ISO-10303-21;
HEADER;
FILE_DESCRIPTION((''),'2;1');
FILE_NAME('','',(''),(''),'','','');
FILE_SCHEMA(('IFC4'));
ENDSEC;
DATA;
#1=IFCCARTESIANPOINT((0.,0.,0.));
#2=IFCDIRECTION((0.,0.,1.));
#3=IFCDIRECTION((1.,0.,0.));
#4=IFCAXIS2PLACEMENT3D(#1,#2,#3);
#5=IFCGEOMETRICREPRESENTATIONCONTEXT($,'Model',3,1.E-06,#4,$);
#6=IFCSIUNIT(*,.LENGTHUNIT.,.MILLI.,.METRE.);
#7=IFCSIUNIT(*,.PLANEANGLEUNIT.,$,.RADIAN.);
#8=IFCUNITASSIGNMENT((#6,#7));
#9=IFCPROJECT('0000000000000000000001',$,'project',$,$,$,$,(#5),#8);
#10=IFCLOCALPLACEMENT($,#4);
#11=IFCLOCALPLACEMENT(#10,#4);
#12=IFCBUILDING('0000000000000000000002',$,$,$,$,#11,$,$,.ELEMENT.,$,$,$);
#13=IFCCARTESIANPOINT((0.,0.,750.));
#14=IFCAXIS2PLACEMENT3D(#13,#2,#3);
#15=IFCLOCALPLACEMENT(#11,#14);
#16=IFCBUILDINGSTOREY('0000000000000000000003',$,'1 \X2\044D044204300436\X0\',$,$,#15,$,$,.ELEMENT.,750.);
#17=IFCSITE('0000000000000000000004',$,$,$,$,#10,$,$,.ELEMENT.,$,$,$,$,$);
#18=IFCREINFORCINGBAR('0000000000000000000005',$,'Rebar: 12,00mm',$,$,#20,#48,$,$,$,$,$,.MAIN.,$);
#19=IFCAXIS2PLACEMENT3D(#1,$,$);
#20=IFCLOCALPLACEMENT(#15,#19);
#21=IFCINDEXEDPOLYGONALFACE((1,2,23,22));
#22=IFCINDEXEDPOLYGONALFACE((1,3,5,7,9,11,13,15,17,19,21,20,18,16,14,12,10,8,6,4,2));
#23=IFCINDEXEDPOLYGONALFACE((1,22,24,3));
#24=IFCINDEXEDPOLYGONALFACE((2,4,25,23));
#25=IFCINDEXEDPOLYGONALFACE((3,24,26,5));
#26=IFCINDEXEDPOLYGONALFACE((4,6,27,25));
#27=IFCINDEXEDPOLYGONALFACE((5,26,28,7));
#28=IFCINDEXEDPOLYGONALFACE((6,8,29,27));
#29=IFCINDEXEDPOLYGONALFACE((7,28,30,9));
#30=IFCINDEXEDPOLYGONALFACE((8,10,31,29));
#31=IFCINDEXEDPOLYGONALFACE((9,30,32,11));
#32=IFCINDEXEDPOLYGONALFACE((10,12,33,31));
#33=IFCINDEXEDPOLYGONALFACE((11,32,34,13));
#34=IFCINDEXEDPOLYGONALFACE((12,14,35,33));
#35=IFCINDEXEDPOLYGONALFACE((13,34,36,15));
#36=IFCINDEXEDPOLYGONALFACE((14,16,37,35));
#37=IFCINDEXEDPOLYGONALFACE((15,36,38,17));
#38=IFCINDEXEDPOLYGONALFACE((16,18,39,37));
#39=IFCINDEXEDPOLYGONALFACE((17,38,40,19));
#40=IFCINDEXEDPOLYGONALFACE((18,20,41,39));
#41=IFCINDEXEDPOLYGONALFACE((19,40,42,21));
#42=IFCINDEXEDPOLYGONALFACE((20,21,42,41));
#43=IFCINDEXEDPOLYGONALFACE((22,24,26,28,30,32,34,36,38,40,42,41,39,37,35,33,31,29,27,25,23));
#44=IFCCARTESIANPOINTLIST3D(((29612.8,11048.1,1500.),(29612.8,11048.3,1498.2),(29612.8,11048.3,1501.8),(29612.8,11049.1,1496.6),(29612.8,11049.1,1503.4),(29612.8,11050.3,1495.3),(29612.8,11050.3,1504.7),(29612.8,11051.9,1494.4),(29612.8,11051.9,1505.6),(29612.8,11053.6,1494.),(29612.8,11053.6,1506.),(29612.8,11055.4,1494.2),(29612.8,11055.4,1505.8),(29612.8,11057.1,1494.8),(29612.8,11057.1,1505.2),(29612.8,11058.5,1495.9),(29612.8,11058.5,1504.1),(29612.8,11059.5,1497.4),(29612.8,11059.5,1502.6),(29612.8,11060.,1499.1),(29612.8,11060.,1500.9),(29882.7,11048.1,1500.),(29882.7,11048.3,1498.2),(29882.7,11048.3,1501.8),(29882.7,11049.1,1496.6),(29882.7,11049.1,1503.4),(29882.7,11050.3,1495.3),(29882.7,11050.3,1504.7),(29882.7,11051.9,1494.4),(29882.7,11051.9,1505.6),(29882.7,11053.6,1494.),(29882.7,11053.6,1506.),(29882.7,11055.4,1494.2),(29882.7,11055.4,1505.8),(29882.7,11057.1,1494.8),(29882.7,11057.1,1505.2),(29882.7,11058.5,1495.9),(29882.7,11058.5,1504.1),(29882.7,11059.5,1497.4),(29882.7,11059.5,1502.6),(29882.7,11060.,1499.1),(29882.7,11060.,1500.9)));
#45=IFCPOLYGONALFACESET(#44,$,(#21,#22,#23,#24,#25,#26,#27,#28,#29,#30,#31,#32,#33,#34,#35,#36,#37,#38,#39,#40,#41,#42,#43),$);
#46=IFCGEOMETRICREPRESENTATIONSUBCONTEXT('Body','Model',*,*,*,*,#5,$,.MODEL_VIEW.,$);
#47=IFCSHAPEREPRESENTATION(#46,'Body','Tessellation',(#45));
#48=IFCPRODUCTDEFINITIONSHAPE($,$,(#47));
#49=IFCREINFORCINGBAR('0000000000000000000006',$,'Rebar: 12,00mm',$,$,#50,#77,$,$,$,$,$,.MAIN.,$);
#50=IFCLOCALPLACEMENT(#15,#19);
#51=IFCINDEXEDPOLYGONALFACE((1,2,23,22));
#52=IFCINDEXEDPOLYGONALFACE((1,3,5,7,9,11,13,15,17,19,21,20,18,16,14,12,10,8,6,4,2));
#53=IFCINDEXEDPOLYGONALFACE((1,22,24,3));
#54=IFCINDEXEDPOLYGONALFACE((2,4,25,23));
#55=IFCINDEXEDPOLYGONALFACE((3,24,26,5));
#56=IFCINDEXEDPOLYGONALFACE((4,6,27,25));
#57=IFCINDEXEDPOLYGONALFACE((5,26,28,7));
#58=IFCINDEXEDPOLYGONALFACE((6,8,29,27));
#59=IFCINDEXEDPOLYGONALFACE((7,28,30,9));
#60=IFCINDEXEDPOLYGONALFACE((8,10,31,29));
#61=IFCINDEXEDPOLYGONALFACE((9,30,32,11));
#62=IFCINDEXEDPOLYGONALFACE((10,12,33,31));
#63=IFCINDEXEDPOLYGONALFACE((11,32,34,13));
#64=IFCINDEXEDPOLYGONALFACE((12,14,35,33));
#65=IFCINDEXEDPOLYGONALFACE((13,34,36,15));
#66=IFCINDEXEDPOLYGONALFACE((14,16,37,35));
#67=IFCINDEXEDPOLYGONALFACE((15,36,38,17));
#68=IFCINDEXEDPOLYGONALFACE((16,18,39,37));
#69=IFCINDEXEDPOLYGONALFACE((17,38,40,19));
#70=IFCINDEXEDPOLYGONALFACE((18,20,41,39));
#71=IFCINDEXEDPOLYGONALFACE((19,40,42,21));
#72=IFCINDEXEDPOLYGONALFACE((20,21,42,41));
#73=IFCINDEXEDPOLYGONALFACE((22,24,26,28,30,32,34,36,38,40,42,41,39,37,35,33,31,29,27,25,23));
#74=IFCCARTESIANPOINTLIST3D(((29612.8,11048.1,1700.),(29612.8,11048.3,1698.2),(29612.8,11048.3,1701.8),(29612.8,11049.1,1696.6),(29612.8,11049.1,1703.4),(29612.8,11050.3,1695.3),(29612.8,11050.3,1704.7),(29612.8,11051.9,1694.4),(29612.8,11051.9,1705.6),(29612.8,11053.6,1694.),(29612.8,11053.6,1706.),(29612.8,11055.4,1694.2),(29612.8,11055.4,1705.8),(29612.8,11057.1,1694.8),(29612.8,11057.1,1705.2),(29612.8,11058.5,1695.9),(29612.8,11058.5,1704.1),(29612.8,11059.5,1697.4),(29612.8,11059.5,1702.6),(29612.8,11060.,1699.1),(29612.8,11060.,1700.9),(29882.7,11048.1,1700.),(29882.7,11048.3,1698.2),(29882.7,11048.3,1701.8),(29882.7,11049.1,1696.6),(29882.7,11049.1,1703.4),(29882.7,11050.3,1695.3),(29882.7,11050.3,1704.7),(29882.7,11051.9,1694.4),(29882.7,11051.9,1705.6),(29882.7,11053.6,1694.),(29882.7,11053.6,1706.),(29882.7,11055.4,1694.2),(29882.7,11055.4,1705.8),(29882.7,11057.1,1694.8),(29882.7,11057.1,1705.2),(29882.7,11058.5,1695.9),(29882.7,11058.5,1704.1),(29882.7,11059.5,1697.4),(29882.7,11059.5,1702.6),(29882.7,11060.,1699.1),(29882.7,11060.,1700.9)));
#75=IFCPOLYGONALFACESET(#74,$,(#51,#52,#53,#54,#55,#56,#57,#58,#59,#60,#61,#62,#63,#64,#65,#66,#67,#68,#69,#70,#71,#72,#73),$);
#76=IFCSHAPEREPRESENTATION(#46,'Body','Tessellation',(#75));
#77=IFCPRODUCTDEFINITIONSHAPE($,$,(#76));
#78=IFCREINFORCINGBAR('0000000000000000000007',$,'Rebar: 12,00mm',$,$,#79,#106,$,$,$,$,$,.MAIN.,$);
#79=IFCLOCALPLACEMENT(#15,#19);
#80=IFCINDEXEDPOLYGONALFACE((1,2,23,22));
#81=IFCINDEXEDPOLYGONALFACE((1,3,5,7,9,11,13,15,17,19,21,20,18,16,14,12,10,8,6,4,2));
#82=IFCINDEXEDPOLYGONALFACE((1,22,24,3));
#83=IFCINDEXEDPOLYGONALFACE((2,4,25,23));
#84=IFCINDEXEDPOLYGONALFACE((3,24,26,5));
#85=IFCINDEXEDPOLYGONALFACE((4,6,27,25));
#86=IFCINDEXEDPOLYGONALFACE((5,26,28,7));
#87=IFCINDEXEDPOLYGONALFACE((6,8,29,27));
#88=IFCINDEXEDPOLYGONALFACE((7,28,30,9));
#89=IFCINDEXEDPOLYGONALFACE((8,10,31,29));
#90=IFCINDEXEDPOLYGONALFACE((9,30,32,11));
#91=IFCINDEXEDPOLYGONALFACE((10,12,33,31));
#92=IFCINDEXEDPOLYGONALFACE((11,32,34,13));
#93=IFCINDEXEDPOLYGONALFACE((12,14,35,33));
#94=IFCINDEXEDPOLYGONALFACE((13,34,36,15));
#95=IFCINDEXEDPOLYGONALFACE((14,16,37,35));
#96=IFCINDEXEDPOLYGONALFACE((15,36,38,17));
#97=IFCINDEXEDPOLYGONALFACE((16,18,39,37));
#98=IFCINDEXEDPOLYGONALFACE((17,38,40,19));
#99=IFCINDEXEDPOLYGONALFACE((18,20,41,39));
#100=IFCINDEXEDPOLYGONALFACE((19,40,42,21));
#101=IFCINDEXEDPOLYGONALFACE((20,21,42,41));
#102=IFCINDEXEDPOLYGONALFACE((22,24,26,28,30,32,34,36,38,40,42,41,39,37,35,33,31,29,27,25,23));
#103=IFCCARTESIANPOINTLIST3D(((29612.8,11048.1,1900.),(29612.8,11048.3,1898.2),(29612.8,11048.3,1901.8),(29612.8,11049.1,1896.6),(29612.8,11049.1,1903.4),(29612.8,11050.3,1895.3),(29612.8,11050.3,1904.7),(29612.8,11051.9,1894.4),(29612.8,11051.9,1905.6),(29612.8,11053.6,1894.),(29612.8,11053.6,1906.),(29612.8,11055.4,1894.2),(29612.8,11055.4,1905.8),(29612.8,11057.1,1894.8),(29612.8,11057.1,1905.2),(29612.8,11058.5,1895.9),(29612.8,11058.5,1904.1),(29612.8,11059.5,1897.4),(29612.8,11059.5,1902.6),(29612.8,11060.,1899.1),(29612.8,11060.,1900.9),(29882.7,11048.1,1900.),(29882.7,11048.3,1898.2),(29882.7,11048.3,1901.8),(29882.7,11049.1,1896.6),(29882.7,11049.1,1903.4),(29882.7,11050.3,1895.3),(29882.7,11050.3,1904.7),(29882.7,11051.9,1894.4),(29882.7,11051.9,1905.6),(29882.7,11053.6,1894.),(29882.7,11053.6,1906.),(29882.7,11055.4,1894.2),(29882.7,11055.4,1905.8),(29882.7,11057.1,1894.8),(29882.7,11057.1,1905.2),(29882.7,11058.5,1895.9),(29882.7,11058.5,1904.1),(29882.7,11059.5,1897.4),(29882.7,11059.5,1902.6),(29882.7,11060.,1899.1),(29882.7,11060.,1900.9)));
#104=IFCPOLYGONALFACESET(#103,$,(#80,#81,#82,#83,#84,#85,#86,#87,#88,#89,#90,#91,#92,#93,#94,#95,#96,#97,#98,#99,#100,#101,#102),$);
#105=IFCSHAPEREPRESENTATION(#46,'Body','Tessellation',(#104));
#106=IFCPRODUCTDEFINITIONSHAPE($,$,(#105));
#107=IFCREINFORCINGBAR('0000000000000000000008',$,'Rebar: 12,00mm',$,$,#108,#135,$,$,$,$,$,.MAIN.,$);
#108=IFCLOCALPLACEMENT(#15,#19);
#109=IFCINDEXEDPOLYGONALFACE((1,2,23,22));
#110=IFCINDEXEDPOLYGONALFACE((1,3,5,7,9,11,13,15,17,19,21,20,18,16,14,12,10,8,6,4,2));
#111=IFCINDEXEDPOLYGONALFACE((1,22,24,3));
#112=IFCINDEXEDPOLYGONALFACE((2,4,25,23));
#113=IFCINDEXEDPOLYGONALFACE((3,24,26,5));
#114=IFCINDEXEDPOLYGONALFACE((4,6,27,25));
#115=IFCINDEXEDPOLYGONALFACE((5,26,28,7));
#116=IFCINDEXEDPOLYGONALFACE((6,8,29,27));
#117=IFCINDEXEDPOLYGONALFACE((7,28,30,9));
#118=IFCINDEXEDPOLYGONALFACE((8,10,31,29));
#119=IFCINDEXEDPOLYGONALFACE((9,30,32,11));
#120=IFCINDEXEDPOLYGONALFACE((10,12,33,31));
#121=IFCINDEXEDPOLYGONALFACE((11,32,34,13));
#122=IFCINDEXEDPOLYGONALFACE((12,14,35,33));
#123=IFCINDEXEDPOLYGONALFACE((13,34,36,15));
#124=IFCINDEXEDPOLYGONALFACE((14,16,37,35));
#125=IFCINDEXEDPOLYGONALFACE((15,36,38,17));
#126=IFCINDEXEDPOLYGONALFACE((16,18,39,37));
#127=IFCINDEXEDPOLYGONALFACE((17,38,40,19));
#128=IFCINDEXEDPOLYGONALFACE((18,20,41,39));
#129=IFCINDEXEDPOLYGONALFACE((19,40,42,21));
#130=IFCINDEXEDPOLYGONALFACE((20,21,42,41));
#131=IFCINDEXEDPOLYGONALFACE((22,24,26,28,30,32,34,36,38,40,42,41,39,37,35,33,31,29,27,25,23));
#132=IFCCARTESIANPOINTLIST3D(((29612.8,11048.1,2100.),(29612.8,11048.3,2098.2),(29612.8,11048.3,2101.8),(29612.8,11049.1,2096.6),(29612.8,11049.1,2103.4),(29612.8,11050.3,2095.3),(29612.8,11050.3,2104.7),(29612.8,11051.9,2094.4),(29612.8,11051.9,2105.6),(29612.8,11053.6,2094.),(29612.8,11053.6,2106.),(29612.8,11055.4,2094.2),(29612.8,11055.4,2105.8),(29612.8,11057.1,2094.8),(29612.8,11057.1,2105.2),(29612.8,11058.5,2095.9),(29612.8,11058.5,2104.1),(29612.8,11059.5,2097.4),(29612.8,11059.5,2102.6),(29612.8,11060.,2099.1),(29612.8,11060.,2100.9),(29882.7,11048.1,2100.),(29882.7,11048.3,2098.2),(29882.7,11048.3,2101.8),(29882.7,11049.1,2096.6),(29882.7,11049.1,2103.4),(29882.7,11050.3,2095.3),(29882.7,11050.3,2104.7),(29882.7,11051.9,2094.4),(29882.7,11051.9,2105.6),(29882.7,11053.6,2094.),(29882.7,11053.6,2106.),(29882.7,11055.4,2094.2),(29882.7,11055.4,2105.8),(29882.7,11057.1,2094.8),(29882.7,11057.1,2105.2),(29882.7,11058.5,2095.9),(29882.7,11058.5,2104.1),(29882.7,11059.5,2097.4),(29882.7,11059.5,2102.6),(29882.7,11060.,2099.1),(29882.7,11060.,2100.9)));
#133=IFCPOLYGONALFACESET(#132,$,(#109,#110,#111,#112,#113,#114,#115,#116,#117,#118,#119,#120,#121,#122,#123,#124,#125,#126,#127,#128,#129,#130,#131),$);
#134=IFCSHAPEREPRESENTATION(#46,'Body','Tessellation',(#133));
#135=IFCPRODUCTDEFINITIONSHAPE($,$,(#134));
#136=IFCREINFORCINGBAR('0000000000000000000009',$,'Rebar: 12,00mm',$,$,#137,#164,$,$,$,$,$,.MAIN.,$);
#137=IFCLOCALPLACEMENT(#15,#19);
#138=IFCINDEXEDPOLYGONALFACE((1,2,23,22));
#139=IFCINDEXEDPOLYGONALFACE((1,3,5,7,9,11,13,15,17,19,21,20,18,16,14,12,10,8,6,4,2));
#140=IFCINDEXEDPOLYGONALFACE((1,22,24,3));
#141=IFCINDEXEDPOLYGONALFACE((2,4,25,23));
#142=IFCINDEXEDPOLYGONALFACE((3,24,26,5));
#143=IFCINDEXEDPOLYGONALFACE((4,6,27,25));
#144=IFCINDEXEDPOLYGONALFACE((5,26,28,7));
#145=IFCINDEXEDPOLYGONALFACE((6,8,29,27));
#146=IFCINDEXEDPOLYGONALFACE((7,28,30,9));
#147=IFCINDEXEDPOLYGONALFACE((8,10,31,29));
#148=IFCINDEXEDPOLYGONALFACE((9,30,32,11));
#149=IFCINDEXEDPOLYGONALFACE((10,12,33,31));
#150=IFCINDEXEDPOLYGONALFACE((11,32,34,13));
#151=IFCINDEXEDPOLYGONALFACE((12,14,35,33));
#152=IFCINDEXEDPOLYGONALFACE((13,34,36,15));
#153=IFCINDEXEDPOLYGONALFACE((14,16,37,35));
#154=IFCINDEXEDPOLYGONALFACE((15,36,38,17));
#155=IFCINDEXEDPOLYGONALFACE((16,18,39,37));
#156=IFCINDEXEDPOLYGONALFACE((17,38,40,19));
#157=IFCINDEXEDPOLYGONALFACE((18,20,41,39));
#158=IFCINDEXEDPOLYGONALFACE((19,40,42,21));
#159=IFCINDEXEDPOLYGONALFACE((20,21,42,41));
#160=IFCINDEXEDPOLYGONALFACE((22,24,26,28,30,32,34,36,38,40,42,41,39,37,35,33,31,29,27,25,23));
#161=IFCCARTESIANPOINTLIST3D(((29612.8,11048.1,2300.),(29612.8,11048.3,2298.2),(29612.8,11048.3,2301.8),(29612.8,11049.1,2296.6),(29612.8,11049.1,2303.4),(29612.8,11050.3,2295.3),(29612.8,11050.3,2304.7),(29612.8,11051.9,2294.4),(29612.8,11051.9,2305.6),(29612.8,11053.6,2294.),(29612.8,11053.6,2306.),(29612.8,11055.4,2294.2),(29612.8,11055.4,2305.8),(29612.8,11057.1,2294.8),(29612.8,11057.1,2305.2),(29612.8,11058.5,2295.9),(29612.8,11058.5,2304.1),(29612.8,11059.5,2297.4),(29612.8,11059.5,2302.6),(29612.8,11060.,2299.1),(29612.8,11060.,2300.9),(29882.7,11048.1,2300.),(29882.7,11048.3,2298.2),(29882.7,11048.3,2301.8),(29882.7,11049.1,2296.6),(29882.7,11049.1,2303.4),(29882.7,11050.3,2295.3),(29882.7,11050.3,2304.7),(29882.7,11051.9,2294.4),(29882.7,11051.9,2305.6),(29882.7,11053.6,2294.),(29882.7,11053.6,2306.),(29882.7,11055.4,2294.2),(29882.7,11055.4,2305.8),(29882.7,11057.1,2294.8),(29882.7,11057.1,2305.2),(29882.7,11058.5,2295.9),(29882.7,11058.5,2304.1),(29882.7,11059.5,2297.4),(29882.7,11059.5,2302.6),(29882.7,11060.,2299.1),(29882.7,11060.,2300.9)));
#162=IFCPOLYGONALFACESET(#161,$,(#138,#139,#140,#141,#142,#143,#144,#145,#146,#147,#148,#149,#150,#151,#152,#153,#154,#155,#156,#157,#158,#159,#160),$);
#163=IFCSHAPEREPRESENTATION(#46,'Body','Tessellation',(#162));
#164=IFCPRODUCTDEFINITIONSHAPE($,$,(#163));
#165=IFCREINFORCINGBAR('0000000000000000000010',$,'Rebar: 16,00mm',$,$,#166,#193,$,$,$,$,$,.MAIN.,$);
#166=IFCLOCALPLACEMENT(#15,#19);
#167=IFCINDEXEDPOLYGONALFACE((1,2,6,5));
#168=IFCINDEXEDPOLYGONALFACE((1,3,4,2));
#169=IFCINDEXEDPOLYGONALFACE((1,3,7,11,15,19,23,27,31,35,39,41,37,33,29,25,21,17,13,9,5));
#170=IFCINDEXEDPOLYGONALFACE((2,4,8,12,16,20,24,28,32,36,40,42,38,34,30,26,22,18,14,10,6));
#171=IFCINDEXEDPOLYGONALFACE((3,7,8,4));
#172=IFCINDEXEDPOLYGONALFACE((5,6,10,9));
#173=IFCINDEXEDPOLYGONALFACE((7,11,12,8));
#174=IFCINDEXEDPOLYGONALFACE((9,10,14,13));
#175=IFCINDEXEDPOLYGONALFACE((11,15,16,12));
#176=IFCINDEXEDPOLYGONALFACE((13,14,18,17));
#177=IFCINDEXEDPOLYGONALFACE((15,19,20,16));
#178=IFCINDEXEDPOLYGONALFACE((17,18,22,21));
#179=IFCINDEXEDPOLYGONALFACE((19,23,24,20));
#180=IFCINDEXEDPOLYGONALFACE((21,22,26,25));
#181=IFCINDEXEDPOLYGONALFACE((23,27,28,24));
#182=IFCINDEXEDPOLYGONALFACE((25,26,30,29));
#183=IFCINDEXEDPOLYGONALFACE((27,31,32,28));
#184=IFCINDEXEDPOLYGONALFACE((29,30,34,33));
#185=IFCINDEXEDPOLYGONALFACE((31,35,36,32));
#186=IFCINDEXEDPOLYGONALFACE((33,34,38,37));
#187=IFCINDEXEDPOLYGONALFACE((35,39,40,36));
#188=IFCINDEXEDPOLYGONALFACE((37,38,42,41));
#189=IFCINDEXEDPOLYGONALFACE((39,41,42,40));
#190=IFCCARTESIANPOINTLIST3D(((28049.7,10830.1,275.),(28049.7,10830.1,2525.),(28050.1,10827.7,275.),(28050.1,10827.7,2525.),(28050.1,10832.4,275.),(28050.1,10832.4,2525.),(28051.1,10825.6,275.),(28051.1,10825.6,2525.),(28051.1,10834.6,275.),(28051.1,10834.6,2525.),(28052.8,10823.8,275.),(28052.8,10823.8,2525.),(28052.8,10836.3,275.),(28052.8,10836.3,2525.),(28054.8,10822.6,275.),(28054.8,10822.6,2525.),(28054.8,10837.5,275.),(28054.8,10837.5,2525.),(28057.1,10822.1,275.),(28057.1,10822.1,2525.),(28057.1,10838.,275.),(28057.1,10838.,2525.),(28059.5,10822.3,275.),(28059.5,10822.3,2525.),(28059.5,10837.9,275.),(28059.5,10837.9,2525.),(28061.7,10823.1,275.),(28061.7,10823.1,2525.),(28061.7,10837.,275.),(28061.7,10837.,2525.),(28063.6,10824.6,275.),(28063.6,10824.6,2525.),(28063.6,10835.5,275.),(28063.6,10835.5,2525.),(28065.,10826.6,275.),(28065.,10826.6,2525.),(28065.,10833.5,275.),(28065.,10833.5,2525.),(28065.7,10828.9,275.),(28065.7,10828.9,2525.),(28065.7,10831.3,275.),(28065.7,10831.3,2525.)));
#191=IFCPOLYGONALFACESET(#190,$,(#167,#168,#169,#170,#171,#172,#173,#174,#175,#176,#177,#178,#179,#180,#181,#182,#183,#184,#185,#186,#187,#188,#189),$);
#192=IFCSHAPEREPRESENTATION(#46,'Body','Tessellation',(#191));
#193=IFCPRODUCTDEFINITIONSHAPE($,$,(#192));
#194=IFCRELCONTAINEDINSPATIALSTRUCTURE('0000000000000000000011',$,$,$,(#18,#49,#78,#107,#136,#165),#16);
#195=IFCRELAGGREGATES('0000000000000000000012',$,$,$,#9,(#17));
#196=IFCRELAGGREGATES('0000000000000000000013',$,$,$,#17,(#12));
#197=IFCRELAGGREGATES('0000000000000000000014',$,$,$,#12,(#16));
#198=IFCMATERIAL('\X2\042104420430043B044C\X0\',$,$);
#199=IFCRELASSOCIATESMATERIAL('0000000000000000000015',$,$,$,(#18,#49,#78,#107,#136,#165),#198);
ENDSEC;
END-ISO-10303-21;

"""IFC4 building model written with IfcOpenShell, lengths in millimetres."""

from ifc_helpers import new_model, entity, si_unit, frame, origin_with_axes, place, context, subcontext, project, spatial, source, transform, mapped, material, element, save


model = new_model("IFC4")

# Units and contexts
model_context = context("Model", 3, precision=1e-06, world=origin_with_axes())
body_context = subcontext(model_context, "Body", "Model", "MODEL_VIEW")
ifc_project = project(units=[si_unit("LENGTHUNIT", "METRE", prefix="MILLI"), si_unit("PLANEANGLEUNIT", "RADIAN")], contexts=[model_context])

# Site, building, storey
site_placement = place(None, origin_with_axes())
site = spatial("IfcSite", under=ifc_project, at=site_placement, CompositionType="ELEMENT")
building_placement = place(site_placement, origin_with_axes())
building = spatial("IfcBuilding", under=site, at=building_placement, CompositionType="ELEMENT")
storey_placement = place(building_placement, frame((0.0, 0.0, 750.0), z_axis=(0.0, 0.0, 1.0), x_axis=(1.0, 0.0, 0.0)))
storey = spatial("IfcBuildingStorey", under=building, at=storey_placement, Name="1 этаж", CompositionType="ELEMENT", Elevation=750.0)

# Reinforcing bars
ifc_material = material(Name="Сталь")
shared_shape_1 = source(origin_with_axes(), body_context, "Body", "AdvancedSweptSolid", [
    entity("IfcSweptDiskSolid", entity("IfcIndexedPolyCurve", entity("IfcCartesianPointList3D", [[0.0, 0.0, 0.0], [270.0, 0.0, 0.0]]), [entity("IfcLineIndex", [1, 2])]), 6.0),
])
reinforcing_bar_1_placement = place(storey_placement, origin_with_axes())
element("IfcReinforcingBar", 1, at=reinforcing_bar_1_placement, inside=storey, material=ifc_material, Name="Rebar: 12,00mm", PredefinedType="MAIN", context=body_context, shape_type="MappedRepresentation", body=[
    mapped(shared_shape_1, transform((29882.7, 11054.1, 1500.0), x_axis=(-1.0, 0.0, 0.0), y_axis=(0.0, -1.0, 0.0), z_axis=(0.0, 0.0, 1.0), scale=1.0)),
])
reinforcing_bar_2_placement = place(storey_placement, origin_with_axes())
element("IfcReinforcingBar", 2, at=reinforcing_bar_2_placement, inside=storey, material=ifc_material, Name="Rebar: 12,00mm", PredefinedType="MAIN", context=body_context, shape_type="MappedRepresentation", body=[
    mapped(shared_shape_1, transform((29882.7, 11054.1, 1700.0), x_axis=(-1.0, 0.0, 0.0), y_axis=(0.0, -1.0, 0.0), z_axis=(0.0, 0.0, 1.0), scale=1.0)),
])
reinforcing_bar_3_placement = place(storey_placement, origin_with_axes())
element("IfcReinforcingBar", 3, at=reinforcing_bar_3_placement, inside=storey, material=ifc_material, Name="Rebar: 12,00mm", PredefinedType="MAIN", context=body_context, shape_type="MappedRepresentation", body=[
    mapped(shared_shape_1, transform((29882.7, 11054.1, 1900.0), x_axis=(-1.0, 0.0, 0.0), y_axis=(0.0, -1.0, 0.0), z_axis=(0.0, 0.0, 1.0), scale=1.0)),
])
reinforcing_bar_4_placement = place(storey_placement, origin_with_axes())
element("IfcReinforcingBar", 4, at=reinforcing_bar_4_placement, inside=storey, material=ifc_material, Name="Rebar: 12,00mm", PredefinedType="MAIN", context=body_context, shape_type="MappedRepresentation", body=[
    mapped(shared_shape_1, transform((29882.7, 11054.1, 2100.0), x_axis=(-1.0, 0.0, 0.0), y_axis=(0.0, -1.0, 0.0), z_axis=(0.0, 0.0, 1.0), scale=1.0)),
])
reinforcing_bar_5_placement = place(storey_placement, origin_with_axes())
element("IfcReinforcingBar", 5, at=reinforcing_bar_5_placement, inside=storey, material=ifc_material, Name="Rebar: 12,00mm", PredefinedType="MAIN", context=body_context, shape_type="MappedRepresentation", body=[
    mapped(shared_shape_1, transform((29882.7, 11054.1, 2300.0), x_axis=(-1.0, 0.0, 0.0), y_axis=(0.0, -1.0, 0.0), z_axis=(0.0, 0.0, 1.0), scale=1.0)),
])
shared_shape_2 = source(origin_with_axes(), body_context, "Body", "AdvancedSweptSolid", [
    entity("IfcSweptDiskSolid", entity("IfcIndexedPolyCurve", entity("IfcCartesianPointList3D", [[0.0, 0.0, 0.0], [2250.0, 0.0, 0.0]]), [entity("IfcLineIndex", [1, 2])]), 8.0),
])
reinforcing_bar_6_placement = place(storey_placement, origin_with_axes())
element("IfcReinforcingBar", 6, at=reinforcing_bar_6_placement, inside=storey, material=ifc_material, Name="Rebar: 16,00mm", PredefinedType="MAIN", context=body_context, shape_type="MappedRepresentation", body=[
    mapped(shared_shape_2, transform((28057.7, 10830.1, 275.0), x_axis=(0.0, 0.0, 1.0), y_axis=(0.0, 1.0, 0.0), z_axis=(-1.0, 0.0, 0.0), scale=1.0)),
])

save(model, "model.ifc")
